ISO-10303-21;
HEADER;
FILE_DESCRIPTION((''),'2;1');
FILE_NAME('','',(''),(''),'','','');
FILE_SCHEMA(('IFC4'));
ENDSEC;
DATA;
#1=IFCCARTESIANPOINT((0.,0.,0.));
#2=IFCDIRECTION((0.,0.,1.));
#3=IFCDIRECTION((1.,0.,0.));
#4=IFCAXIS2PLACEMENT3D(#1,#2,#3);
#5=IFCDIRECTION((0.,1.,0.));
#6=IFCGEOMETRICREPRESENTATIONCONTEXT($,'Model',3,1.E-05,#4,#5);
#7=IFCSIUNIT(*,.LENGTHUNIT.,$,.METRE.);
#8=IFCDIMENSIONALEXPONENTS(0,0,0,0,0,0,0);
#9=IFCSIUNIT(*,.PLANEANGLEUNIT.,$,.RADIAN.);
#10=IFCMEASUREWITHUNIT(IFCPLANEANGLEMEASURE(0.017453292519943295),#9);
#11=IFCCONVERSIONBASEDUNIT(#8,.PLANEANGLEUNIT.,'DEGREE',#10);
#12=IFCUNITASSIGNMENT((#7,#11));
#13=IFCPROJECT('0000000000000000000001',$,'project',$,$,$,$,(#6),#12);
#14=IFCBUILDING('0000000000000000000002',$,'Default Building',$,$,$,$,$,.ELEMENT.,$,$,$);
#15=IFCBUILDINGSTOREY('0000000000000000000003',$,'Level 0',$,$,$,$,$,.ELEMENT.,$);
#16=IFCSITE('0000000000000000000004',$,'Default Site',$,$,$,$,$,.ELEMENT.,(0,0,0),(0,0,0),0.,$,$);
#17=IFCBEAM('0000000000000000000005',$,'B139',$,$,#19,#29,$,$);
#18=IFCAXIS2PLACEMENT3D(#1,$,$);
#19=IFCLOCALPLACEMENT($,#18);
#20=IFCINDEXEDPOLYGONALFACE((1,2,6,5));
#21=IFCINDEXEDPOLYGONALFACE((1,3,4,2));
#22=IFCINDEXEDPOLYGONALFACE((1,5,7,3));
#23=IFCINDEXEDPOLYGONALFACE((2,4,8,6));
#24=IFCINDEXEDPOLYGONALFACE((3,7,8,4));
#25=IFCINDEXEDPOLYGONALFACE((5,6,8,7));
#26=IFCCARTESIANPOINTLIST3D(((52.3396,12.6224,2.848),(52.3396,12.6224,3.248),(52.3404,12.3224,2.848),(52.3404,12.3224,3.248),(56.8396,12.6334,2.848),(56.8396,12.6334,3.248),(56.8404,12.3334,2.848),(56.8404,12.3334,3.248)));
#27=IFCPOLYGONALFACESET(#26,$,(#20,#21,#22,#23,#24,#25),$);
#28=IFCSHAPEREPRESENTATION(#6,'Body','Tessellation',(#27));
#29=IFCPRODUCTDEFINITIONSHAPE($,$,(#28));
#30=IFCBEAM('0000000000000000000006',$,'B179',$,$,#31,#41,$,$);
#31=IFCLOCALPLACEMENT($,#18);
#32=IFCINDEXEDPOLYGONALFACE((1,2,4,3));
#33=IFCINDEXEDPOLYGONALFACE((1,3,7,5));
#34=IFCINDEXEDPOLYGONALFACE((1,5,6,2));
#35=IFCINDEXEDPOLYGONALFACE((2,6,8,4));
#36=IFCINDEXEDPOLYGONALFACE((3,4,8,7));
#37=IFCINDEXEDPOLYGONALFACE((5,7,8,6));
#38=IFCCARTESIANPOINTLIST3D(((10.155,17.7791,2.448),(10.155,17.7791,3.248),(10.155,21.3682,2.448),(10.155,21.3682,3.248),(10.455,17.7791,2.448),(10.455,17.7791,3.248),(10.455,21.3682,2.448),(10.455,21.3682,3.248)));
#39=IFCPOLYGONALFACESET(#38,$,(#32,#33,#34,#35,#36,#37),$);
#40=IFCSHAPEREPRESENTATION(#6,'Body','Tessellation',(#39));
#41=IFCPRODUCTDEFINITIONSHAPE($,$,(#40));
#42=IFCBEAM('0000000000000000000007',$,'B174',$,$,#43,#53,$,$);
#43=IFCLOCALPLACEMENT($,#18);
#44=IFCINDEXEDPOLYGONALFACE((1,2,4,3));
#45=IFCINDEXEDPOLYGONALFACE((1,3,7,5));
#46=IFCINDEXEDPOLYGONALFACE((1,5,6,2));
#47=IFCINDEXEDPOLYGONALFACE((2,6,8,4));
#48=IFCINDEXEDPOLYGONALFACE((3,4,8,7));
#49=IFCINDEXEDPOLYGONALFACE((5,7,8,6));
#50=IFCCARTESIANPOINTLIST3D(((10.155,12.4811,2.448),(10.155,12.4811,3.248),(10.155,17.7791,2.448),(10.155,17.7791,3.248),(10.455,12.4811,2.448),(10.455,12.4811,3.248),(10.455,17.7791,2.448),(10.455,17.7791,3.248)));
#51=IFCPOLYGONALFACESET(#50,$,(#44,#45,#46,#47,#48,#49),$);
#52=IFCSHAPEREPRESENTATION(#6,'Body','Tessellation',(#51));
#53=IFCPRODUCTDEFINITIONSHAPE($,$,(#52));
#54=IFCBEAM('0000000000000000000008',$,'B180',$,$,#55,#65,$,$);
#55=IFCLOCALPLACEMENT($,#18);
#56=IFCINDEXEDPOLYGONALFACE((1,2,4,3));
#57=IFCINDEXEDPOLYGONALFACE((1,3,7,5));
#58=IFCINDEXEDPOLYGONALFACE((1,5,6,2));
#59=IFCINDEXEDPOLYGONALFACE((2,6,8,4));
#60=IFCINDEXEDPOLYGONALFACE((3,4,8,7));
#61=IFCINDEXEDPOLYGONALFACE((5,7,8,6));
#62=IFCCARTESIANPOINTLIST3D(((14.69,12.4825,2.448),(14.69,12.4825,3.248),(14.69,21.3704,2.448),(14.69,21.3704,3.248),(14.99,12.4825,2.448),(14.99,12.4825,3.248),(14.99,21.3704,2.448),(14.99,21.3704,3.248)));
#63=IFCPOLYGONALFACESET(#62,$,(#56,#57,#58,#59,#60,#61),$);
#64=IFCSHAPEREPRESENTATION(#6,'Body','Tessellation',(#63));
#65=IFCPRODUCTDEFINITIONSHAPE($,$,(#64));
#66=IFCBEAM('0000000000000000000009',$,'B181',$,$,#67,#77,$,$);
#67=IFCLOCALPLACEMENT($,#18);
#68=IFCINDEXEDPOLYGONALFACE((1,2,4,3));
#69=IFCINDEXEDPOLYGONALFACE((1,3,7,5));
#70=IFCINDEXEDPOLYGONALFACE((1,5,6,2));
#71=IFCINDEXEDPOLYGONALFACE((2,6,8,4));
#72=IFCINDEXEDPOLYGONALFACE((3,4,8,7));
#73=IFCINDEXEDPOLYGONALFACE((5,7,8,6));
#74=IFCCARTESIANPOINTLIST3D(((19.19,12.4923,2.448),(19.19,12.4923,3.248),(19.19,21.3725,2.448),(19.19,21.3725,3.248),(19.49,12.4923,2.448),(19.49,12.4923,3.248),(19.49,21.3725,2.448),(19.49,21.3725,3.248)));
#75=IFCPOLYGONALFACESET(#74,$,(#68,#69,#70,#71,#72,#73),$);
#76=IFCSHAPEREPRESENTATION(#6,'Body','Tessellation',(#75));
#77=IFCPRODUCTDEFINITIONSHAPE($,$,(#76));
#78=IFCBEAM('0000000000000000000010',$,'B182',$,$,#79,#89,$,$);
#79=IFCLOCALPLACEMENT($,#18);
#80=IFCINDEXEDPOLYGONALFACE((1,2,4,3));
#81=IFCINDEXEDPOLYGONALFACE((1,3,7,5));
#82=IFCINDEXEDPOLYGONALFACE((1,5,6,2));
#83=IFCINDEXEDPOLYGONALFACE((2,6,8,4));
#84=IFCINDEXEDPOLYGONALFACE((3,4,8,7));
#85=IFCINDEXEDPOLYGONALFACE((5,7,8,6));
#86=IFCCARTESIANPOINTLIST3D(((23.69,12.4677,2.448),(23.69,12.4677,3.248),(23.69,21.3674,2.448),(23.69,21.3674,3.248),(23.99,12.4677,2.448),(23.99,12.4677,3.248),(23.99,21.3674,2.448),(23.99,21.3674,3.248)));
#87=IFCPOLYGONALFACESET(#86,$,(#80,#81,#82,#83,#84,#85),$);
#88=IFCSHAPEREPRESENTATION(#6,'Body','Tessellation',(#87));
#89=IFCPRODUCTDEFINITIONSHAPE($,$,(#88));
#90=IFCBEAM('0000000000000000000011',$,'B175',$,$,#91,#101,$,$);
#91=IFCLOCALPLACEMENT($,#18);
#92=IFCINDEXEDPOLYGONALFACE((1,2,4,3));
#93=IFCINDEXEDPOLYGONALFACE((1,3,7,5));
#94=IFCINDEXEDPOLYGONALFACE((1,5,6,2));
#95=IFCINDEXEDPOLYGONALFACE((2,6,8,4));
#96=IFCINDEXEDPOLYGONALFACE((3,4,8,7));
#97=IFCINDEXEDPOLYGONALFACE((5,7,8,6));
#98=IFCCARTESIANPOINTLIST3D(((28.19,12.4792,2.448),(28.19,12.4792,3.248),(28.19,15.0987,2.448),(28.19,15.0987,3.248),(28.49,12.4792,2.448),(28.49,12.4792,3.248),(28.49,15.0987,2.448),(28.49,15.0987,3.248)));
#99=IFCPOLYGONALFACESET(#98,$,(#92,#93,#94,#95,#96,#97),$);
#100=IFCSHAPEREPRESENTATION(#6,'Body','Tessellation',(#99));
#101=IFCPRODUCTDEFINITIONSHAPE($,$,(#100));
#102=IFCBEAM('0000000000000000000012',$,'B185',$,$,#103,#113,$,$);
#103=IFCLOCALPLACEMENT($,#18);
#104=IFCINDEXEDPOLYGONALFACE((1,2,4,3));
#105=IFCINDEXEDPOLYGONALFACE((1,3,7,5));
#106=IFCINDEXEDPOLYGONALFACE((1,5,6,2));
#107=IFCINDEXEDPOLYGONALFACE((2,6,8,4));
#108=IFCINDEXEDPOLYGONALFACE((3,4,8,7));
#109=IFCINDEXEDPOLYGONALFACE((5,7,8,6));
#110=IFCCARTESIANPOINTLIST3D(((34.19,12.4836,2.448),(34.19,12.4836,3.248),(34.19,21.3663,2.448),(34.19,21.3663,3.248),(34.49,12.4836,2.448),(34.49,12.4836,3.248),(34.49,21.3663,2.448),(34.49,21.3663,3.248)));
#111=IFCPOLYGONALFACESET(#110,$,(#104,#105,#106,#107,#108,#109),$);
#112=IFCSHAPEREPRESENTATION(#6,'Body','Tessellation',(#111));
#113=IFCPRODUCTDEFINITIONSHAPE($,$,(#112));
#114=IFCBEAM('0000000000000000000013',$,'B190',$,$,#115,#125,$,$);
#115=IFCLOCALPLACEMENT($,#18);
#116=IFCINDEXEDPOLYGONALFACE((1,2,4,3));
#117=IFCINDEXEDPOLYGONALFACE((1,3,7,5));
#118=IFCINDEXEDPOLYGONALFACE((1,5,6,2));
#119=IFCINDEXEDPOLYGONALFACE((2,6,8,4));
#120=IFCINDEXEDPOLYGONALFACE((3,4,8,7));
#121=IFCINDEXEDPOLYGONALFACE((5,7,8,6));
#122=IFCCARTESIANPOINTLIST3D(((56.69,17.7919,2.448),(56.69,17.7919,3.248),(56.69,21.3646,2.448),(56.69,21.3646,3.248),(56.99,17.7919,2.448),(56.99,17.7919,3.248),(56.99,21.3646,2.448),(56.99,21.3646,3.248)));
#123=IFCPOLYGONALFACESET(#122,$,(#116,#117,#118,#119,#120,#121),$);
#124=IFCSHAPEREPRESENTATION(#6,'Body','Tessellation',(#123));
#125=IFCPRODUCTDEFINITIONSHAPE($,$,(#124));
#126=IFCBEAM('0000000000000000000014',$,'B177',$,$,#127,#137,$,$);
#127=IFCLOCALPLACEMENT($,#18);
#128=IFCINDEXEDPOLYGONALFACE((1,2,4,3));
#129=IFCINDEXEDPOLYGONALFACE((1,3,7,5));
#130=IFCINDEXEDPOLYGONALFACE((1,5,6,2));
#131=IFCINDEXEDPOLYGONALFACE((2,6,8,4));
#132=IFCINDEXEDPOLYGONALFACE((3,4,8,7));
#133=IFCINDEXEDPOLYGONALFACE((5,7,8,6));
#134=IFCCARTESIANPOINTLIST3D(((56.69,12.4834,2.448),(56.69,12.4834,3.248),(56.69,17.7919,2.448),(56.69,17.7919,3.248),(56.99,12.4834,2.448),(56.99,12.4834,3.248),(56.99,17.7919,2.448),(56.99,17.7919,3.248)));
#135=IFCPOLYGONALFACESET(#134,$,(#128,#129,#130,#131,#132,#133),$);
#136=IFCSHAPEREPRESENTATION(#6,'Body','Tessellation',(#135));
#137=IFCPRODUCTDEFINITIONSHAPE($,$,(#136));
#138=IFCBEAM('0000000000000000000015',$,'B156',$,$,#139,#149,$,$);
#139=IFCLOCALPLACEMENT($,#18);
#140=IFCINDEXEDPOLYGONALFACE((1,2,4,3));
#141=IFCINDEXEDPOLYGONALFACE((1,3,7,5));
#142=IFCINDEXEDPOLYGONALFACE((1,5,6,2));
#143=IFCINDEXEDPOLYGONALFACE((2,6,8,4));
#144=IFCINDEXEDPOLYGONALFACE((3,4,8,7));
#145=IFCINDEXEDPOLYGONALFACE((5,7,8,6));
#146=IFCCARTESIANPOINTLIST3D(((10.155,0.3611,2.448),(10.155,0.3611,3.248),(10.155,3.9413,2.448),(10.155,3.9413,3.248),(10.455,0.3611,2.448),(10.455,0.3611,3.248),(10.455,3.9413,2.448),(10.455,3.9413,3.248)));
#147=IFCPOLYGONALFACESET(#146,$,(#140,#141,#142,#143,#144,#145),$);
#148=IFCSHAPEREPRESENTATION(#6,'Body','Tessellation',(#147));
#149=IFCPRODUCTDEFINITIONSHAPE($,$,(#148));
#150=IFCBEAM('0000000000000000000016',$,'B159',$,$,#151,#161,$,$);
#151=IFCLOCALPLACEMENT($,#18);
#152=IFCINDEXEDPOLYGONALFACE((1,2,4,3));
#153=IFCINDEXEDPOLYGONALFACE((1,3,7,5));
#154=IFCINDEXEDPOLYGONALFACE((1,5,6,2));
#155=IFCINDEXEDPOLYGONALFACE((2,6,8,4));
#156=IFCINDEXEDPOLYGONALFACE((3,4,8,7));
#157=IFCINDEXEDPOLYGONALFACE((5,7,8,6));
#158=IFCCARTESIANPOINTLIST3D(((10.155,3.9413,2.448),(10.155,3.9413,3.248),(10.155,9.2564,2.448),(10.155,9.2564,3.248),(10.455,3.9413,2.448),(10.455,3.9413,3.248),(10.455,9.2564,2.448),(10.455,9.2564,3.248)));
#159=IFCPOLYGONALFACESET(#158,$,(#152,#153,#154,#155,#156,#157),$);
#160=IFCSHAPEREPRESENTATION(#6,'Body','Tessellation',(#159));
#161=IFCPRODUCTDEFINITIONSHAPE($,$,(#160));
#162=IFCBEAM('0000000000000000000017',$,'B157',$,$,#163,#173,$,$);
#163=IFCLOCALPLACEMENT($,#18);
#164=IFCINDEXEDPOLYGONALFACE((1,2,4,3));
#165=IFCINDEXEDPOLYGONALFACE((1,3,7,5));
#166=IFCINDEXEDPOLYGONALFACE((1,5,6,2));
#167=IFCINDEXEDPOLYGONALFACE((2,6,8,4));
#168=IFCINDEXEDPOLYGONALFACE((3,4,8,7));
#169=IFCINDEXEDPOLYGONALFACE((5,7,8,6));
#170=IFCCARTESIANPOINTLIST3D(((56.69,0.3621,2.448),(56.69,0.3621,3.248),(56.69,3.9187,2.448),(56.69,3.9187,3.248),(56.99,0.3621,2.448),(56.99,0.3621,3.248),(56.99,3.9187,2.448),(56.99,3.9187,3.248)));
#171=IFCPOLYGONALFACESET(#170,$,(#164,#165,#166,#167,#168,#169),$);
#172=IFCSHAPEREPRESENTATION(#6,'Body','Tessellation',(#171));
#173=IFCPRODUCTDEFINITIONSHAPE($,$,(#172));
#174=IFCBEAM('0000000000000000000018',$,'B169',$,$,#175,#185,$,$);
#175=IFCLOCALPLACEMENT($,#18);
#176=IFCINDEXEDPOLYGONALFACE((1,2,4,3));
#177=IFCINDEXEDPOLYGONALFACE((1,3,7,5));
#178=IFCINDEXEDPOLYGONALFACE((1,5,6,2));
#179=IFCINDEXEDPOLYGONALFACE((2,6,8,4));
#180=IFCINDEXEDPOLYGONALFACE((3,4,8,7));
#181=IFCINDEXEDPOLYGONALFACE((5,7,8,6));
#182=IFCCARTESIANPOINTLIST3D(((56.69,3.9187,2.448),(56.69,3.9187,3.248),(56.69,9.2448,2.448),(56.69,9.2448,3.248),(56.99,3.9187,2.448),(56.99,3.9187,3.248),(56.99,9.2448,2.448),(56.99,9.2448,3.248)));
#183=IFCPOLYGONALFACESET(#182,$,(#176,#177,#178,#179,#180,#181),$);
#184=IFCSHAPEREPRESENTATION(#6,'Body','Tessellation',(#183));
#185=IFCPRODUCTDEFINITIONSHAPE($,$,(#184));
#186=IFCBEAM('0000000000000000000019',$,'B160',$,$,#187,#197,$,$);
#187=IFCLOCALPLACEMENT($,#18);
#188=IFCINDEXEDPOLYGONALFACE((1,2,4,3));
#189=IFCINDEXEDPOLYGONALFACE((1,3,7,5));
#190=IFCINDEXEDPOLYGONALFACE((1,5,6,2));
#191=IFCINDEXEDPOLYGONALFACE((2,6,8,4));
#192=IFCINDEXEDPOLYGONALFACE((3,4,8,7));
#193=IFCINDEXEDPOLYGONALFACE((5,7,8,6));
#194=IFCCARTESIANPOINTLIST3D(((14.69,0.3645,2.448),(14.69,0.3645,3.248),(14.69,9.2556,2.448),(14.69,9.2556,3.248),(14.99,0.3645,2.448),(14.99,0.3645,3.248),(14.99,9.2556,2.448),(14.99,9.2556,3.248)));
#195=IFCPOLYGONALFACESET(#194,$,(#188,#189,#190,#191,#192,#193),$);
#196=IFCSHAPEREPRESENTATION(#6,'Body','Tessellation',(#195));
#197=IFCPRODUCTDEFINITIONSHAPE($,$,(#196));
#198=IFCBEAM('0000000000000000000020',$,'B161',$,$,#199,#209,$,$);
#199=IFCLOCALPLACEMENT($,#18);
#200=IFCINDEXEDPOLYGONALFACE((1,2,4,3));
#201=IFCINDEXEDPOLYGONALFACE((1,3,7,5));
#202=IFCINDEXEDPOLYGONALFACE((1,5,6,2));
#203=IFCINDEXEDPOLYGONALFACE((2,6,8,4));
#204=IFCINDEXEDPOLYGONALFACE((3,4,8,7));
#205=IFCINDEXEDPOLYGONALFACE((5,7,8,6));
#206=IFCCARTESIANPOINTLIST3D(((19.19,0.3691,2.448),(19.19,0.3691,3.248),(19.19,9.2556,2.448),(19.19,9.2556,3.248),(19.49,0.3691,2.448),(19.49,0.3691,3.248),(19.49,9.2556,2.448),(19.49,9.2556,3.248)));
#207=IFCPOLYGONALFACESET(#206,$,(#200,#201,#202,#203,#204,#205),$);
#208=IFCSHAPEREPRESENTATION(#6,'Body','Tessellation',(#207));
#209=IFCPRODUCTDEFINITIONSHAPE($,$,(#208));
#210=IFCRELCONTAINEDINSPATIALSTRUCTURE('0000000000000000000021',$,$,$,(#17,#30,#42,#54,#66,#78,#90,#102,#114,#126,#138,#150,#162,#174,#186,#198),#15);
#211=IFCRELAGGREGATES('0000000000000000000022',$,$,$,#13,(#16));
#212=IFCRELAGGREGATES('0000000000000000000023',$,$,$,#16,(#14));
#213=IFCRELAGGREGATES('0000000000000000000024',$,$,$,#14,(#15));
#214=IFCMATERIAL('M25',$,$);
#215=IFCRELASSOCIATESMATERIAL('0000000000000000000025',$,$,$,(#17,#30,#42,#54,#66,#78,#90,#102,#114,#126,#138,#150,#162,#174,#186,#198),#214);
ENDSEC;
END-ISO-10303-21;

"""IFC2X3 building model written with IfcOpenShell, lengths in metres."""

from ifc_helpers import new_model, entity, si_unit, converted_unit, direction, frame, frame_2d, origin_with_axes, place, context, project, spatial, rectangle, extrude, material, element, save


model = new_model("IFC2X3")

# Units and contexts
model_context = context("Model", 3, precision=1e-05, world=origin_with_axes(), true_north=direction((0.0, 1.0, 0.0)))
ifc_project = project(units=[si_unit("LENGTHUNIT", "METRE"), converted_unit("PLANEANGLEUNIT", "DEGREE", entity("IfcPlaneAngleMeasure", 0.017453292519943295), si_unit("PLANEANGLEUNIT", "RADIAN"), dimensions=[0, 0, 0, 0, 0, 0, 0])], contexts=[model_context])

# Site, building, storey
site = spatial("IfcSite", under=ifc_project, Name="Default Site", CompositionType="ELEMENT", RefLatitude=(0, 0, 0), RefLongitude=(0, 0, 0), RefElevation=0.0)
building = spatial("IfcBuilding", under=site, Name="Default Building", CompositionType="ELEMENT")
storey = spatial("IfcBuildingStorey", under=building, Name="Level 0", CompositionType="ELEMENT")

# Beams
ifc_material = material(Name="M25")
placement = place(None, origin_with_axes())
element("IfcBeam", 1, at=placement, inside=storey, material=ifc_material, Name="B139", context=model_context, shape_type="SweptSolid", body=[
    extrude(rectangle(XDim=0.3, YDim=0.4, at=frame_2d((0.0, 0.0), x_axis=(0.0, 1.0, 0.0))), frame((52.34, 12.4724, 3.048), z_axis=(0.999997, 0.002456, 0.0), x_axis=(0.0, 0.0, -1.0)), (0.0, 0.0, 1.0), 4.5),
])
element("IfcBeam", 2, at=placement, inside=storey, material=ifc_material, Name="B179", context=model_context, shape_type="SweptSolid", body=[
    extrude(rectangle(XDim=0.3, YDim=0.8, at=frame_2d((0.0, 0.0), x_axis=(0.0, 1.0, 0.0))), frame((10.305, 21.3682, 2.848), z_axis=(0.0, -1.0, 0.0), x_axis=(0.0, 0.0, -1.0)), (0.0, 0.0, 1.0), 3.5891),
])
element("IfcBeam", 3, at=placement, inside=storey, material=ifc_material, Name="B174", context=model_context, shape_type="SweptSolid", body=[
    extrude(rectangle(XDim=0.3, YDim=0.8, at=frame_2d((0.0, 0.0), x_axis=(0.0, 1.0, 0.0))), frame((10.305, 17.7791, 2.848), z_axis=(0.0, -1.0, 0.0), x_axis=(0.0, 0.0, -1.0)), (0.0, 0.0, 1.0), 5.298),
])
element("IfcBeam", 4, at=placement, inside=storey, material=ifc_material, Name="B180", context=model_context, shape_type="SweptSolid", body=[
    extrude(rectangle(XDim=0.3, YDim=0.8, at=frame_2d((0.0, 0.0), x_axis=(0.0, 1.0, 0.0))), frame((14.84, 21.3704, 2.848), z_axis=(0.0, -1.0, 0.0), x_axis=(0.0, 0.0, -1.0)), (0.0, 0.0, 1.0), 8.8879),
])
element("IfcBeam", 5, at=placement, inside=storey, material=ifc_material, Name="B181", context=model_context, shape_type="SweptSolid", body=[
    extrude(rectangle(XDim=0.3, YDim=0.8, at=frame_2d((0.0, 0.0), x_axis=(0.0, 1.0, 0.0))), frame((19.34, 21.3725, 2.848), z_axis=(0.0, -1.0, 0.0), x_axis=(0.0, 0.0, -1.0)), (0.0, 0.0, 1.0), 8.8802),
])
element("IfcBeam", 6, at=placement, inside=storey, material=ifc_material, Name="B182", context=model_context, shape_type="SweptSolid", body=[
    extrude(rectangle(XDim=0.3, YDim=0.8, at=frame_2d((0.0, 0.0), x_axis=(0.0, 1.0, 0.0))), frame((23.84, 21.3674, 2.848), z_axis=(0.0, -1.0, 0.0), x_axis=(0.0, 0.0, -1.0)), (0.0, 0.0, 1.0), 8.8997),
])
element("IfcBeam", 7, at=placement, inside=storey, material=ifc_material, Name="B175", context=model_context, shape_type="SweptSolid", body=[
    extrude(rectangle(XDim=0.3, YDim=0.8, at=frame_2d((0.0, 0.0), x_axis=(0.0, 1.0, 0.0))), frame((28.34, 15.0987, 2.848), z_axis=(0.0, -1.0, 0.0), x_axis=(0.0, 0.0, -1.0)), (0.0, 0.0, 1.0), 2.6195),
])
element("IfcBeam", 8, at=placement, inside=storey, material=ifc_material, Name="B185", context=model_context, shape_type="SweptSolid", body=[
    extrude(rectangle(XDim=0.3, YDim=0.8, at=frame_2d((0.0, 0.0), x_axis=(0.0, 1.0, 0.0))), frame((34.34, 12.4836, 2.848), z_axis=(0.0, 1.0, 0.0), x_axis=(0.0, 0.0, -1.0)), (0.0, 0.0, 1.0), 8.8827),
])
element("IfcBeam", 9, at=placement, inside=storey, material=ifc_material, Name="B190", context=model_context, shape_type="SweptSolid", body=[
    extrude(rectangle(XDim=0.3, YDim=0.8, at=frame_2d((0.0, 0.0), x_axis=(0.0, 1.0, 0.0))), frame((56.84, 17.7919, 2.848), z_axis=(0.0, 1.0, 0.0), x_axis=(0.0, 0.0, -1.0)), (0.0, 0.0, 1.0), 3.5727),
])
element("IfcBeam", 10, at=placement, inside=storey, material=ifc_material, Name="B177", context=model_context, shape_type="SweptSolid", body=[
    extrude(rectangle(XDim=0.3, YDim=0.8, at=frame_2d((0.0, 0.0), x_axis=(0.0, 1.0, 0.0))), frame((56.84, 12.4834, 2.848), z_axis=(0.0, 1.0, 0.0), x_axis=(0.0, 0.0, -1.0)), (0.0, 0.0, 1.0), 5.3085),
])
element("IfcBeam", 11, at=placement, inside=storey, material=ifc_material, Name="B156", context=model_context, shape_type="SweptSolid", body=[
    extrude(rectangle(XDim=0.3, YDim=0.8, at=frame_2d((0.0, 0.0), x_axis=(0.0, 1.0, 0.0))), frame((10.305, 3.9413, 2.848), z_axis=(0.0, -1.0, 0.0), x_axis=(0.0, 0.0, -1.0)), (0.0, 0.0, 1.0), 3.5802),
])
element("IfcBeam", 12, at=placement, inside=storey, material=ifc_material, Name="B159", context=model_context, shape_type="SweptSolid", body=[
    extrude(rectangle(XDim=0.3, YDim=0.8, at=frame_2d((0.0, 0.0), x_axis=(0.0, 1.0, 0.0))), frame((10.305, 3.9413, 2.848), z_axis=(0.0, 1.0, 0.0), x_axis=(0.0, 0.0, -1.0)), (0.0, 0.0, 1.0), 5.3151),
])
element("IfcBeam", 13, at=placement, inside=storey, material=ifc_material, Name="B157", context=model_context, shape_type="SweptSolid", body=[
    extrude(rectangle(XDim=0.3, YDim=0.8, at=frame_2d((0.0, 0.0), x_axis=(0.0, 1.0, 0.0))), frame((56.84, 0.3621, 2.848), z_axis=(0.0, 1.0, 0.0), x_axis=(0.0, 0.0, -1.0)), (0.0, 0.0, 1.0), 3.5566),
])
element("IfcBeam", 14, at=placement, inside=storey, material=ifc_material, Name="B169", context=model_context, shape_type="SweptSolid", body=[
    extrude(rectangle(XDim=0.3, YDim=0.8, at=frame_2d((0.0, 0.0), x_axis=(0.0, 1.0, 0.0))), frame((56.84, 3.9187, 2.848), z_axis=(0.0, 1.0, 0.0), x_axis=(0.0, 0.0, -1.0)), (0.0, 0.0, 1.0), 5.3261),
])
element("IfcBeam", 15, at=placement, inside=storey, material=ifc_material, Name="B160", context=model_context, shape_type="SweptSolid", body=[
    extrude(rectangle(XDim=0.3, YDim=0.8, at=frame_2d((0.0, 0.0), x_axis=(0.0, 1.0, 0.0))), frame((14.84, 0.3645, 2.848), z_axis=(0.0, 1.0, 0.0), x_axis=(0.0, 0.0, -1.0)), (0.0, 0.0, 1.0), 8.891),
])
element("IfcBeam", 16, at=placement, inside=storey, material=ifc_material, Name="B161", context=model_context, shape_type="SweptSolid", body=[
    extrude(rectangle(XDim=0.3, YDim=0.8, at=frame_2d((0.0, 0.0), x_axis=(0.0, 1.0, 0.0))), frame((19.34, 0.3691, 2.848), z_axis=(0.0, 1.0, 0.0), x_axis=(0.0, 0.0, -1.0)), (0.0, 0.0, 1.0), 8.8865),
])

save(model, "model.ifc")
